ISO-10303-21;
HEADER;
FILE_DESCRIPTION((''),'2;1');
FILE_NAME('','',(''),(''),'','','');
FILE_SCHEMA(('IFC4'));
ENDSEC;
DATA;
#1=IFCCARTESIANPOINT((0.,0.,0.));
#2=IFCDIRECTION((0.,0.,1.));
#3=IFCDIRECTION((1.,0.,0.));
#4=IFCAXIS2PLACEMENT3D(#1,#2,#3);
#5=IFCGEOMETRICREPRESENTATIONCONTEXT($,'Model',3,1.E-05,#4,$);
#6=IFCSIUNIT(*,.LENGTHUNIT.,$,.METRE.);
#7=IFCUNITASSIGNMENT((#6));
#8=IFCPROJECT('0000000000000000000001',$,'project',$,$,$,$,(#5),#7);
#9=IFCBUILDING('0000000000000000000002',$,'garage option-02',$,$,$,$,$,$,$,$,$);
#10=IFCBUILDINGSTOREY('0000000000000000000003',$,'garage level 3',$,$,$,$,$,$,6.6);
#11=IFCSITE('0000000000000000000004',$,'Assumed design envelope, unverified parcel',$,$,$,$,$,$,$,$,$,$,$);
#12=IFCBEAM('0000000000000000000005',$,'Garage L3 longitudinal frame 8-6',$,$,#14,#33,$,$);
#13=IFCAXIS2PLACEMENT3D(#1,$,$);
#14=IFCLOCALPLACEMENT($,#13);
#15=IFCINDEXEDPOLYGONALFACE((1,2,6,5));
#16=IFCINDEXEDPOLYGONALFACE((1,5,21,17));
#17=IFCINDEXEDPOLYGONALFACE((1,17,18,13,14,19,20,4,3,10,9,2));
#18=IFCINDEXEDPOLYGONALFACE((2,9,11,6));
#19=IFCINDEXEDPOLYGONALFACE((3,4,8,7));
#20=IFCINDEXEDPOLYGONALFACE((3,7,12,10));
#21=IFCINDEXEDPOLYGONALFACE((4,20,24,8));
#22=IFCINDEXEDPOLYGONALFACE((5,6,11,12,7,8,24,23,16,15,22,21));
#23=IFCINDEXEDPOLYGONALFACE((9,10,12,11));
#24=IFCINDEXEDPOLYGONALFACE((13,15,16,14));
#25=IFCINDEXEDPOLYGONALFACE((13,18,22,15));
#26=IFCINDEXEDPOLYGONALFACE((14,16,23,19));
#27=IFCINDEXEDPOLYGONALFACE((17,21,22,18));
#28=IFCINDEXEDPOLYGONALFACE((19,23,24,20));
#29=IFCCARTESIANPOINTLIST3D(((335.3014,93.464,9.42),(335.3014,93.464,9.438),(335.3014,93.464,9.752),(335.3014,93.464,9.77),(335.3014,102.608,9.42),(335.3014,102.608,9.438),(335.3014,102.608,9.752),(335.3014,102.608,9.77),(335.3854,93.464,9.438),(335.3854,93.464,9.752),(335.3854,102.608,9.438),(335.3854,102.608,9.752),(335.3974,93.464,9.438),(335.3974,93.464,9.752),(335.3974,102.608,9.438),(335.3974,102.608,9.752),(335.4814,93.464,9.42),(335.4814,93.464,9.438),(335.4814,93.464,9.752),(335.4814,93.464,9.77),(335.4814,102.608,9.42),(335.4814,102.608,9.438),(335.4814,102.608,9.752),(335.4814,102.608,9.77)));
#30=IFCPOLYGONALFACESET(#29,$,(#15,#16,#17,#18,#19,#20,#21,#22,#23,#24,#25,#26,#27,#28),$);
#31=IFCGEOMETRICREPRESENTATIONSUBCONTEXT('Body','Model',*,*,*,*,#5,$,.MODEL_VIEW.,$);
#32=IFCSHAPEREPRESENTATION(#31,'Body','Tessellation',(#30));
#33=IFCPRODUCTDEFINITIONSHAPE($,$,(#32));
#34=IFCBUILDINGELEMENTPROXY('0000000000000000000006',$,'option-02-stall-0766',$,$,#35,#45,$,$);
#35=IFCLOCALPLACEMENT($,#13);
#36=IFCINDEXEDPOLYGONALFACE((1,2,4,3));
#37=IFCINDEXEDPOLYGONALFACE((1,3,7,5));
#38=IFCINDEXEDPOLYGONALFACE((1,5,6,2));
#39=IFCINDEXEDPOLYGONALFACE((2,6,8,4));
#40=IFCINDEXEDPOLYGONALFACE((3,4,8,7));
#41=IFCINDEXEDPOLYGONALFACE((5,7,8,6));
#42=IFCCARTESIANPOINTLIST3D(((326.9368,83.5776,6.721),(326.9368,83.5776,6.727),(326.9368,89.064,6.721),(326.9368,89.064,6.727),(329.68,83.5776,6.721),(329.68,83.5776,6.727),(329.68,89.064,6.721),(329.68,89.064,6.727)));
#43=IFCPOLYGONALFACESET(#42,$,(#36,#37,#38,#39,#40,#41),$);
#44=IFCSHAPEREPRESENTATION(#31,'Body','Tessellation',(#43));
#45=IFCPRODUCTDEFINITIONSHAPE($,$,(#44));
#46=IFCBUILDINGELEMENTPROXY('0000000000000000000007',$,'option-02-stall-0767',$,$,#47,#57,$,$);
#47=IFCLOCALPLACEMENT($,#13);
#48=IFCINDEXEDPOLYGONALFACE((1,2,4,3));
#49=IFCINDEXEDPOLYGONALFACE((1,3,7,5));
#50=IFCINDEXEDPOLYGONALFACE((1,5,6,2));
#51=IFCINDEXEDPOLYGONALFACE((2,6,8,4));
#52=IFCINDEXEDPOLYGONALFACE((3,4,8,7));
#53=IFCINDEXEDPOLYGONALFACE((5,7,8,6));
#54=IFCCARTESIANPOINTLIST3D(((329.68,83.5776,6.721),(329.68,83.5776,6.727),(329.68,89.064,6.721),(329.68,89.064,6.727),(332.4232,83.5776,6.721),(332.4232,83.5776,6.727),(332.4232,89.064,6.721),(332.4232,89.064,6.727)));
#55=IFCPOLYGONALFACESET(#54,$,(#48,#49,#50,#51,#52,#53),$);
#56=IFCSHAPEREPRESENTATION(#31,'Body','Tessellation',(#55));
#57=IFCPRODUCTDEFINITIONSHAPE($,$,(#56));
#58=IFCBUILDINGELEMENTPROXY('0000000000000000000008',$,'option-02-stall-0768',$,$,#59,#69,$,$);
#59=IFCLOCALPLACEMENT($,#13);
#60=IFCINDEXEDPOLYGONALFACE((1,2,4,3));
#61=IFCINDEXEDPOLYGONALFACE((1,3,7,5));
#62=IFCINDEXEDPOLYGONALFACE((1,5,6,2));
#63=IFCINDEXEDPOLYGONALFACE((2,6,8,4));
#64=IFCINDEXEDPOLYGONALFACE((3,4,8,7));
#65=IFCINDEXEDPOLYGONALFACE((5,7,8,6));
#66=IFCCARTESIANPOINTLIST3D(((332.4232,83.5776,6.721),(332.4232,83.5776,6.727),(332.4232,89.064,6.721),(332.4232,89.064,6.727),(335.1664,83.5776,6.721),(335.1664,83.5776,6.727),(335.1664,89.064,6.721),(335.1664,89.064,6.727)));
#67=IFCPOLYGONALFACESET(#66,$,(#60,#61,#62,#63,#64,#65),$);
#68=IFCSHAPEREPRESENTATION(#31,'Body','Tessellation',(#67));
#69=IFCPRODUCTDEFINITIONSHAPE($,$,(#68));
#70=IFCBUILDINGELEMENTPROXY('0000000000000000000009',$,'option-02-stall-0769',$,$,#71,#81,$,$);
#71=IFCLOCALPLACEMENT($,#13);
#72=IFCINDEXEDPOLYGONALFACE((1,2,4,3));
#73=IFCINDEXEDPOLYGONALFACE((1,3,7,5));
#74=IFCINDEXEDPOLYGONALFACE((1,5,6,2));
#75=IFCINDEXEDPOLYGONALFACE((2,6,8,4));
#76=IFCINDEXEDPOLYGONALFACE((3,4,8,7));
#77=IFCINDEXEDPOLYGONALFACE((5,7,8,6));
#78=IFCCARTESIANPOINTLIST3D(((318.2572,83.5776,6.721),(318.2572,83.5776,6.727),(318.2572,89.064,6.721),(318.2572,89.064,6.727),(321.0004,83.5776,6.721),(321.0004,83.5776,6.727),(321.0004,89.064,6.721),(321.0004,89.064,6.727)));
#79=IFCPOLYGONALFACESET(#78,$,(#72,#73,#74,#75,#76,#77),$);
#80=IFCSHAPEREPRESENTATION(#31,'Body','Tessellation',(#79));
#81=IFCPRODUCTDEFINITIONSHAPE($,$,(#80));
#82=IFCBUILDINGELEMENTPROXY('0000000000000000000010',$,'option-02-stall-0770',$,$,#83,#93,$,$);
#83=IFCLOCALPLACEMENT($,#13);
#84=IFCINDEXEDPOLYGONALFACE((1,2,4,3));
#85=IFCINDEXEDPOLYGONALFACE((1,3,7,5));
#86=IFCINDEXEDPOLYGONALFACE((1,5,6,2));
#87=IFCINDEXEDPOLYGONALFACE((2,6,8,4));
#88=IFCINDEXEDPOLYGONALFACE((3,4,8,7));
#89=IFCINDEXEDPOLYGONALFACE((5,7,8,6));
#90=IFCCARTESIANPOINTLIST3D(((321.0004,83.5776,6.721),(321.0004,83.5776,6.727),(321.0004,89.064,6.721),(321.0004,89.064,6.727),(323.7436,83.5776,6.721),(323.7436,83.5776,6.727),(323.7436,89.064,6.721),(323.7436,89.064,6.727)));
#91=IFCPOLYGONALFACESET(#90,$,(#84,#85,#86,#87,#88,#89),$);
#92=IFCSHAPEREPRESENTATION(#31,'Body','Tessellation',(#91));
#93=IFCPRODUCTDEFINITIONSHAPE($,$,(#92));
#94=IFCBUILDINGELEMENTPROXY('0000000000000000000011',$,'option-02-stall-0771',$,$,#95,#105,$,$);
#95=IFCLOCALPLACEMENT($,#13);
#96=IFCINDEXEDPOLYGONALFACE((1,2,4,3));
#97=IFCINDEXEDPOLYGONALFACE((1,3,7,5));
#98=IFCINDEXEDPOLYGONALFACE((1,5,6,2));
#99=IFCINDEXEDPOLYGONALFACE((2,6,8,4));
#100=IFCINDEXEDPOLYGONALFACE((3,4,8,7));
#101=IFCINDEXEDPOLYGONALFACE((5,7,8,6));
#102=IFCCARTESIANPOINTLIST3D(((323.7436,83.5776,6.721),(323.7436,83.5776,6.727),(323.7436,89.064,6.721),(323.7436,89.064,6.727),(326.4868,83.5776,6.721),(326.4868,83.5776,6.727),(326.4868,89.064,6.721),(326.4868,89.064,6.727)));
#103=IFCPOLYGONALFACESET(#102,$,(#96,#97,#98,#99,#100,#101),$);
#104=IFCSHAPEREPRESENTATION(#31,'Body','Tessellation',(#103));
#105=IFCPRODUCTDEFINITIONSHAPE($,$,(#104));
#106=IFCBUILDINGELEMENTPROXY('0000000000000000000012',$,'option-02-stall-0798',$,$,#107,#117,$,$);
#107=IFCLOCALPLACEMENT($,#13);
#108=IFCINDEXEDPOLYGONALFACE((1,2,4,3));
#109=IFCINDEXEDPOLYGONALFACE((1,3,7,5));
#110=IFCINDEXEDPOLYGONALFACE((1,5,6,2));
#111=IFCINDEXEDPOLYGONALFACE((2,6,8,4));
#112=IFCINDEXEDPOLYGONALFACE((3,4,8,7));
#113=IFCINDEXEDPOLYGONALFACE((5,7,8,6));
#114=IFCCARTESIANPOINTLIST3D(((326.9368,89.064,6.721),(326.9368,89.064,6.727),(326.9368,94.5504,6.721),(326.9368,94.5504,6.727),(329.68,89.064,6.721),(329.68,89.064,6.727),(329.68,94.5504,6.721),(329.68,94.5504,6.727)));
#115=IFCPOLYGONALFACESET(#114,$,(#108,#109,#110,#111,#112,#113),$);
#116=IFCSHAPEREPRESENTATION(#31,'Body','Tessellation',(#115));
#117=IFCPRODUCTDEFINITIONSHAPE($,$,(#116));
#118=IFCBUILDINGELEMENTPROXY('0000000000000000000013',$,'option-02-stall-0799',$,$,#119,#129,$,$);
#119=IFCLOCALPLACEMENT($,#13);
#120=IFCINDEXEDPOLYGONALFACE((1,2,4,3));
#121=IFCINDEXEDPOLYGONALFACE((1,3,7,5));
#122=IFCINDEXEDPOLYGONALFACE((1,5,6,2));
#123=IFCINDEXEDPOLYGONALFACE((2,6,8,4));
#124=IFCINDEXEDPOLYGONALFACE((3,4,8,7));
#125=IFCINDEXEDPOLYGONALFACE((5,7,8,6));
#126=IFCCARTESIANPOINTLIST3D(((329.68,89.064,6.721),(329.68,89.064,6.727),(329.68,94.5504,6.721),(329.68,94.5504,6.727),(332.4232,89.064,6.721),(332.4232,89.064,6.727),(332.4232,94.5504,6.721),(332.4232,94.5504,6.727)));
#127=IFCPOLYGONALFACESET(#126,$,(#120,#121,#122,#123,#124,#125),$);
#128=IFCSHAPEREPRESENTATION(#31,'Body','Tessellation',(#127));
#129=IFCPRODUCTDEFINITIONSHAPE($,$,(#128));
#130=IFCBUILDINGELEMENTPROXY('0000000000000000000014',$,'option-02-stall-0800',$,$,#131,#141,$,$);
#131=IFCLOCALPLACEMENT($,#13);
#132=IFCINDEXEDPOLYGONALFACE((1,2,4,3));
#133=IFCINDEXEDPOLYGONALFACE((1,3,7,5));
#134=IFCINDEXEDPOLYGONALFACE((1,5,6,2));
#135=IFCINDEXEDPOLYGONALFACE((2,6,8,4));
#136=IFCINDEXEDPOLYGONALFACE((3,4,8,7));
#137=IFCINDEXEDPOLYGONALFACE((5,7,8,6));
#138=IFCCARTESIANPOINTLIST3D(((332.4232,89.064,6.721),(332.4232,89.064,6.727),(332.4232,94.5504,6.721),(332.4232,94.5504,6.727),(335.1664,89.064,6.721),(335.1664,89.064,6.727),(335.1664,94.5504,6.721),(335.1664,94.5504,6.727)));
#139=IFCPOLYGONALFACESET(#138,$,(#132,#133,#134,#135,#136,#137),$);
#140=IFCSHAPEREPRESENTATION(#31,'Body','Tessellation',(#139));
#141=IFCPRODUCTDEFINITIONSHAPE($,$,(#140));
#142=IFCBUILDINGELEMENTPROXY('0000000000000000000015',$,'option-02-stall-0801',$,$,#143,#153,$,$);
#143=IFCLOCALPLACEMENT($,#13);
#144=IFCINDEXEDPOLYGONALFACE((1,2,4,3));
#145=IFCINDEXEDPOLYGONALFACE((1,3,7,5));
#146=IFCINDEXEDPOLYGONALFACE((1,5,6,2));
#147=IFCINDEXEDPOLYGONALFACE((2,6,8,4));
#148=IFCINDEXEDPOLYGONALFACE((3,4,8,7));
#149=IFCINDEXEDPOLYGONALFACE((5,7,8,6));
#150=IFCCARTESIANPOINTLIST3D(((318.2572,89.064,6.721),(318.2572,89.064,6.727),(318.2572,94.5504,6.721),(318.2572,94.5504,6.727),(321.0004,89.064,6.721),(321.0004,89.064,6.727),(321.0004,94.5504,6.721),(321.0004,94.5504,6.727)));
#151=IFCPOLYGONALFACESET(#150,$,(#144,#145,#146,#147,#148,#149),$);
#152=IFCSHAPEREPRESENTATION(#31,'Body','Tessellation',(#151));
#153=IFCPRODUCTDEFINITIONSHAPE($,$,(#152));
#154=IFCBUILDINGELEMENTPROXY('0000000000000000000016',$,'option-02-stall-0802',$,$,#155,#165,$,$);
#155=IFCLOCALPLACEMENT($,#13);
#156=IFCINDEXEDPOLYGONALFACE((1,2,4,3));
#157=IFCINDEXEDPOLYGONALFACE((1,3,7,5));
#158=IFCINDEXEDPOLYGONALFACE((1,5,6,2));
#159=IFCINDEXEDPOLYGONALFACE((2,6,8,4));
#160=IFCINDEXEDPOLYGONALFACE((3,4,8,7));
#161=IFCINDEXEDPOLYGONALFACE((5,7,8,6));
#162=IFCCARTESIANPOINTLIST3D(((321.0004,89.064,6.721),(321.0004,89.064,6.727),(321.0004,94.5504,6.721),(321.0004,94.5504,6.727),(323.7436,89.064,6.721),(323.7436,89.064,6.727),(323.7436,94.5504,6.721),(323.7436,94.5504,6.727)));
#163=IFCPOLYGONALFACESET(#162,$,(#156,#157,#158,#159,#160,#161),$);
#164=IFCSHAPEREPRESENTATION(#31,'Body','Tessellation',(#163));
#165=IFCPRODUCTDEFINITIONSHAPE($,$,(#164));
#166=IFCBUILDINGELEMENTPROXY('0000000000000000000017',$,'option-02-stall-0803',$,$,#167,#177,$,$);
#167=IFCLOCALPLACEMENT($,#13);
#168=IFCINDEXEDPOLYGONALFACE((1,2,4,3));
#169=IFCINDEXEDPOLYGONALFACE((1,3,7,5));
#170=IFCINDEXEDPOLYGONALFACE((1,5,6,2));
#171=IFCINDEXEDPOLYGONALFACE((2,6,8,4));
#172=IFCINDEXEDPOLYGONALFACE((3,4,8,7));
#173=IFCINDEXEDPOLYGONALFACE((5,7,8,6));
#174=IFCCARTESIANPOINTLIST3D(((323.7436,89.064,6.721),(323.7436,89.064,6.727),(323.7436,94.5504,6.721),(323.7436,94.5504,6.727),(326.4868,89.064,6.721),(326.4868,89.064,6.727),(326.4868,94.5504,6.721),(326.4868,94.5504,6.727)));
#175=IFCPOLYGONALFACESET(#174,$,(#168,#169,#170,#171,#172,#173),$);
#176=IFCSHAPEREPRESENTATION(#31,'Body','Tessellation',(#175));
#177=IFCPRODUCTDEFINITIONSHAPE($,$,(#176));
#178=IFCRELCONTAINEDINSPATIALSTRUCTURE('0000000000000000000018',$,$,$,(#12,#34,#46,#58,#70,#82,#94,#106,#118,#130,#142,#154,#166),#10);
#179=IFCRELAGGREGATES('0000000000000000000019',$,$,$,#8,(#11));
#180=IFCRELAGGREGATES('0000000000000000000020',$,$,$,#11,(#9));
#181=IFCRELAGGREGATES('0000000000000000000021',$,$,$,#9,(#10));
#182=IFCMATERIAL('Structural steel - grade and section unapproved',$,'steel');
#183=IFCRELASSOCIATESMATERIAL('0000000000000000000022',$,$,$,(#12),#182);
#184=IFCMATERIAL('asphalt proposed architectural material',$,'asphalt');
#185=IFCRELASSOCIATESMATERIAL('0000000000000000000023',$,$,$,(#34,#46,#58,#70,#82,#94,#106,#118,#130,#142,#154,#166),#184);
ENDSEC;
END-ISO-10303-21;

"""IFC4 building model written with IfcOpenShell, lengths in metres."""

from ifc_helpers import new_model, si_unit, frame, origin_with_axes, place, context, subcontext, project, spatial, rectangle, i_section, extrude, material, element, save


model = new_model("IFC4")

# Units and contexts
model_context = context("Model", 3, precision=1e-05, world=origin_with_axes())
body_context = subcontext(model_context, "Body", "Model", "MODEL_VIEW")
ifc_project = project(units=[si_unit("LENGTHUNIT", "METRE")], contexts=[model_context])

# Site, building, storey
site = spatial("IfcSite", under=ifc_project, Name="Assumed design envelope, unverified parcel")
building = spatial("IfcBuilding", under=site, Name="garage option-02")
storey = spatial("IfcBuildingStorey", under=building, Name="garage level 3", Elevation=6.6)

# Beam
ifc_material_1 = material(Name="Structural steel - grade and section unapproved", Category="steel")
beam_1_placement = place(None, frame((335.3914, 93.464, 9.595), z_axis=(0.0, 1.0, 0.0), x_axis=(-1.0, 0.0, 0.0)))
element("IfcBeam", 1, at=beam_1_placement, inside=storey, material=ifc_material_1, Name="Garage L3 longitudinal frame 8-6", context=body_context, shape_type="SweptSolid", body=[
    extrude(i_section(OverallWidth=0.18, OverallDepth=0.35, WebThickness=0.012, FlangeThickness=0.018, FilletRadius=0.0), origin_with_axes(), (0.0, 0.0, 1.0), 9.144),
])

# Building element proxies
ifc_material_2 = material(Name="asphalt proposed architectural material", Category="asphalt")
for number, where, z_axis, x_axis, name in (
    (2, (328.3084, 86.3208, 6.721), (0.0, 0.0, 1.0), (1.0, 0.0, 0.0), "option-02-stall-0766"),
    (3, (331.0516, 86.3208, 6.721), (0.0, 0.0, 1.0), (1.0, 0.0, 0.0), "option-02-stall-0767"),
    (4, (333.7948, 86.3208, 6.721), (0.0, 0.0, 1.0), (1.0, 0.0, 0.0), "option-02-stall-0768"),
    (5, (319.6288, 86.3208, 6.721), (0.0, 0.0, 1.0), (1.0, 0.0, 0.0), "option-02-stall-0769"),
    (6, (322.372, 86.3208, 6.721), (0.0, 0.0, 1.0), (1.0, 0.0, 0.0), "option-02-stall-0770"),
    (7, (325.1152, 86.3208, 6.721), (0.0, 0.0, 1.0), (1.0, 0.0, 0.0), "option-02-stall-0771"),
    (8, (328.3084, 91.8072, 6.721), (0.0, 0.0, 1.0), (1.0, 0.0, 0.0), "option-02-stall-0798"),
    (9, (331.0516, 91.8072, 6.721), (0.0, 0.0, 1.0), (1.0, 0.0, 0.0), "option-02-stall-0799"),
    (10, (333.7948, 91.8072, 6.721), (0.0, 0.0, 1.0), (1.0, 0.0, 0.0), "option-02-stall-0800"),
    (11, (319.6288, 91.8072, 6.721), (0.0, 0.0, 1.0), (1.0, 0.0, 0.0), "option-02-stall-0801"),
    (12, (322.372, 91.8072, 6.721), (0.0, 0.0, 1.0), (1.0, 0.0, 0.0), "option-02-stall-0802"),
    (13, (325.1152, 91.8072, 6.721), (0.0, 0.0, 1.0), (1.0, 0.0, 0.0), "option-02-stall-0803"),
):
    element("IfcBuildingElementProxy", number, at=place(None, frame(where, z_axis=z_axis, x_axis=x_axis)), inside=storey, material=ifc_material_2, Name=name, context=body_context, shape_type="SweptSolid", body=[
        extrude(rectangle(XDim=2.7432, YDim=5.4864), origin_with_axes(), (0.0, 0.0, 1.0), 0.006),
    ])

save(model, "model.ifc")
